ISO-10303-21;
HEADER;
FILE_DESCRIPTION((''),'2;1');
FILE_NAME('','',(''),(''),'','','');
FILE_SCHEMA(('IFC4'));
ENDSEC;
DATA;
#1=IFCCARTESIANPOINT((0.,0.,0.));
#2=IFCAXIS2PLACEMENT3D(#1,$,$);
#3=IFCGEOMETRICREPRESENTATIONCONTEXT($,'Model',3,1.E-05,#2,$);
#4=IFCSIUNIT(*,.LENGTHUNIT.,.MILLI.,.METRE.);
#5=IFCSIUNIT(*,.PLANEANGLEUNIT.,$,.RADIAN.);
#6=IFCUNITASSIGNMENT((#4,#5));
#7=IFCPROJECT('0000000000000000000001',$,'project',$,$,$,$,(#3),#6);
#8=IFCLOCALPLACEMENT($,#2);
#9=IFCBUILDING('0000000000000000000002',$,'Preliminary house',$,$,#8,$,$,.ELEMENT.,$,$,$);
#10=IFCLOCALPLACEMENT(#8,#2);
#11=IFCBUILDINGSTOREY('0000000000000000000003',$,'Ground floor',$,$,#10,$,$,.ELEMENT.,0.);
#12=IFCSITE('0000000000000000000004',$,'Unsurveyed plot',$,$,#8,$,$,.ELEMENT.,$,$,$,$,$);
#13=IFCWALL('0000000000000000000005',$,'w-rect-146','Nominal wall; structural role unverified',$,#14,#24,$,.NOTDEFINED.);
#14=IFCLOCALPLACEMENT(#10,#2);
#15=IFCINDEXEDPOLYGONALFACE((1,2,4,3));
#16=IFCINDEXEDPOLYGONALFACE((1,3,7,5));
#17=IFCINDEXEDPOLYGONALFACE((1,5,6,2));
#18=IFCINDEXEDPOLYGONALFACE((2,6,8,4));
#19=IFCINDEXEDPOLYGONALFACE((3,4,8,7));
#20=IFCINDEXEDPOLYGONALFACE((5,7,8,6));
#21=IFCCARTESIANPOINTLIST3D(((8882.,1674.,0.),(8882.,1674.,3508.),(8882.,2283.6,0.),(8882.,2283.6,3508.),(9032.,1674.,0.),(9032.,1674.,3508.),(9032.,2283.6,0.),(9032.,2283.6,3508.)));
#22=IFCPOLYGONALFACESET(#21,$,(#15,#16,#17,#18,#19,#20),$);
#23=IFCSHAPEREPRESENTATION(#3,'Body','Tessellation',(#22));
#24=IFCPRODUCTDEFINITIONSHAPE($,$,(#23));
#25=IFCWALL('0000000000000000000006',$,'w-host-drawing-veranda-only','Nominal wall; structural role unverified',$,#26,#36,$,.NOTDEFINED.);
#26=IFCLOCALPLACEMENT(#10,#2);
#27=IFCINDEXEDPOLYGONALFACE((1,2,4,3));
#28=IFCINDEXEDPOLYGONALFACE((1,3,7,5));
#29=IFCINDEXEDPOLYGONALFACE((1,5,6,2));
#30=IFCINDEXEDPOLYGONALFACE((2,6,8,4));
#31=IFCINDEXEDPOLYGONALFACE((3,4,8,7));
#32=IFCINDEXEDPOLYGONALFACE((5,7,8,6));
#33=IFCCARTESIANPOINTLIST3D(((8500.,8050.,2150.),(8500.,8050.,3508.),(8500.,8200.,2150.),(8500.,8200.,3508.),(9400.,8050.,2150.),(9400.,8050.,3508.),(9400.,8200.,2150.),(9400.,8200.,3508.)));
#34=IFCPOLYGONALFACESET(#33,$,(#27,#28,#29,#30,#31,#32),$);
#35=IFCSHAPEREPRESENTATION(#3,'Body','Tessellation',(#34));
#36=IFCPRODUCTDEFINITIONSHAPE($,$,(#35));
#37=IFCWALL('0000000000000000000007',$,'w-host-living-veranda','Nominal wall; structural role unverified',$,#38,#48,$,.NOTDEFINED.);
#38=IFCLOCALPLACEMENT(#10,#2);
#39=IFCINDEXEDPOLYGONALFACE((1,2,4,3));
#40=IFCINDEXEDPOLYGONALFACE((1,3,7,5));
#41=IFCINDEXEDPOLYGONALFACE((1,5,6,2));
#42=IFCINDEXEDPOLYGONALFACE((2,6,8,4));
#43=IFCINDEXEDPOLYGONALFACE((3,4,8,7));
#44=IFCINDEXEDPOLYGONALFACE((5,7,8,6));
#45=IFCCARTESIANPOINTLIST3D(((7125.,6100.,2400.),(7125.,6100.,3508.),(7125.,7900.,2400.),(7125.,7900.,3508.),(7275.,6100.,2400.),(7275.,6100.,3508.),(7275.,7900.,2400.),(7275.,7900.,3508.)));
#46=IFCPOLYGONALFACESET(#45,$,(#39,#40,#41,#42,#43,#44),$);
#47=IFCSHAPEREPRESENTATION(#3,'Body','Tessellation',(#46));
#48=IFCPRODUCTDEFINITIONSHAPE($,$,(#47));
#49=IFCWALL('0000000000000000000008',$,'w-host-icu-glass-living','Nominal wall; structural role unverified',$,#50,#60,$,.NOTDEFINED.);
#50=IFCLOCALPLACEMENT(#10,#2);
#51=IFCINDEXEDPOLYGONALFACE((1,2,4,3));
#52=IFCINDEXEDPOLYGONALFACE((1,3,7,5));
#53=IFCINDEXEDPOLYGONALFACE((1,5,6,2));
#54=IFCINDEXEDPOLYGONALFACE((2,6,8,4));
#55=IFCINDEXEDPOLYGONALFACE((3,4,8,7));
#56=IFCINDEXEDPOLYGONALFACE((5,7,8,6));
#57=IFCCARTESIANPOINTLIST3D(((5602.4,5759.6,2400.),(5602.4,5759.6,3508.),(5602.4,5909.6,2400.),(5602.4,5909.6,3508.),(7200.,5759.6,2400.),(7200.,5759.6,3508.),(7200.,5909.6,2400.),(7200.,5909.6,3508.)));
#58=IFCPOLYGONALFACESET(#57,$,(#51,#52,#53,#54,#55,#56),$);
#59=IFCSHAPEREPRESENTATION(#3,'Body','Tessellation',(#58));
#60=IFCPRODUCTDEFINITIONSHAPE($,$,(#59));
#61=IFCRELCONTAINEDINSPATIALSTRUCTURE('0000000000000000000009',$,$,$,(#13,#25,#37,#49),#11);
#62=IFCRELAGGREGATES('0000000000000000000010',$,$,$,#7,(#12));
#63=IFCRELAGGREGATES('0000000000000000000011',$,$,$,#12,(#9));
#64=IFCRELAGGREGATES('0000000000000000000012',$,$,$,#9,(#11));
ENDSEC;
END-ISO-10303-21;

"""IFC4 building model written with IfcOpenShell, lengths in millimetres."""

from ifc_helpers import new_model, si_unit, origin, place, context, project, spatial, polyline, outline, extrude, element, save


model = new_model("IFC4")

# Units and contexts
model_context = context("Model", 3, precision=1e-05, world=origin())
ifc_project = project(units=[si_unit("LENGTHUNIT", "METRE", prefix="MILLI"), si_unit("PLANEANGLEUNIT", "RADIAN")], contexts=[model_context])

# Site, building, storey
placement_1 = place(None, origin())
site = spatial("IfcSite", under=ifc_project, at=placement_1, Name="Unsurveyed plot", CompositionType="ELEMENT")
building = spatial("IfcBuilding", under=site, at=placement_1, Name="Preliminary house", CompositionType="ELEMENT")
placement_2 = place(placement_1, origin())
storey = spatial("IfcBuildingStorey", under=building, at=placement_2, Name="Ground floor", CompositionType="ELEMENT", Elevation=0.0)

# Wall
element("IfcWall", 1, at=placement_2, inside=storey, Name="w-rect-146", Description="Nominal wall; structural role unverified", PredefinedType="NOTDEFINED", context=model_context, shape_type="SweptSolid", body=[
    extrude(outline(polyline([(8882.0, 1674.0), (9032.0, 1674.0), (9032.0, 2283.6), (8882.0, 2283.6), (8882.0, 1674.0)])), origin(), (0.0, 0.0, 1.0), 3508.0),
])

# Walls, openings
wall_1 = element("IfcWall", 2, at=placement_2, inside=storey, Name="w-host-drawing-veranda-only", Description="Nominal wall; structural role unverified", PredefinedType="NOTDEFINED", context=model_context, shape_type="SweptSolid", body=[
    extrude(outline(polyline([(8500.0, 8050.0), (9400.0, 8050.0), (9400.0, 8200.0), (8500.0, 8200.0), (8500.0, 8050.0)])), origin(), (0.0, 0.0, 1.0), 3508.0),
])
element("IfcOpeningElement", 3, at=placement_2, cuts=wall_1, PredefinedType="OPENING", context=model_context, shape_type="SweptSolid", body=[
    extrude(outline(polyline([(8500.0, 7675.0), (9400.0, 7675.0), (9400.0, 8575.0), (8500.0, 8575.0), (8500.0, 7675.0)])), origin(), (0.0, 0.0, 1.0), 2150.0),
])
wall_2 = element("IfcWall", 4, at=placement_2, inside=storey, Name="w-host-living-veranda", Description="Nominal wall; structural role unverified", PredefinedType="NOTDEFINED", context=model_context, shape_type="SweptSolid", body=[
    extrude(outline(polyline([(7275.0, 6100.0), (7275.0, 7900.0), (7125.0, 7900.0), (7125.0, 6100.0), (7275.0, 6100.0)])), origin(), (0.0, 0.0, 1.0), 3508.0),
])
element("IfcOpeningElement", 5, at=placement_2, cuts=wall_2, PredefinedType="OPENING", context=model_context, shape_type="SweptSolid", body=[
    extrude(outline(polyline([(7650.0, 6100.0), (7650.0, 7900.0), (6750.0, 7900.0), (6750.0, 6100.0), (7650.0, 6100.0)])), origin(), (0.0, 0.0, 1.0), 2400.0),
])
wall_3 = element("IfcWall", 6, at=placement_2, inside=storey, Name="w-host-icu-glass-living", Description="Nominal wall; structural role unverified", PredefinedType="NOTDEFINED", context=model_context, shape_type="SweptSolid", body=[
    extrude(outline(polyline([(5602.4, 5759.6), (7200.0, 5759.6), (7200.0, 5909.6), (5602.4, 5909.6), (5602.4, 5759.6)])), origin(), (0.0, 0.0, 1.0), 3508.0),
])
element("IfcOpeningElement", 7, at=placement_2, cuts=wall_3, PredefinedType="OPENING", context=model_context, shape_type="SweptSolid", body=[
    extrude(outline(polyline([(5602.4, 5384.6), (7200.0, 5384.6), (7200.0, 6284.6), (5602.4, 6284.6), (5602.4, 5384.6)])), origin(), (0.0, 0.0, 1.0), 2400.0),
])

save(model, "model.ifc")
